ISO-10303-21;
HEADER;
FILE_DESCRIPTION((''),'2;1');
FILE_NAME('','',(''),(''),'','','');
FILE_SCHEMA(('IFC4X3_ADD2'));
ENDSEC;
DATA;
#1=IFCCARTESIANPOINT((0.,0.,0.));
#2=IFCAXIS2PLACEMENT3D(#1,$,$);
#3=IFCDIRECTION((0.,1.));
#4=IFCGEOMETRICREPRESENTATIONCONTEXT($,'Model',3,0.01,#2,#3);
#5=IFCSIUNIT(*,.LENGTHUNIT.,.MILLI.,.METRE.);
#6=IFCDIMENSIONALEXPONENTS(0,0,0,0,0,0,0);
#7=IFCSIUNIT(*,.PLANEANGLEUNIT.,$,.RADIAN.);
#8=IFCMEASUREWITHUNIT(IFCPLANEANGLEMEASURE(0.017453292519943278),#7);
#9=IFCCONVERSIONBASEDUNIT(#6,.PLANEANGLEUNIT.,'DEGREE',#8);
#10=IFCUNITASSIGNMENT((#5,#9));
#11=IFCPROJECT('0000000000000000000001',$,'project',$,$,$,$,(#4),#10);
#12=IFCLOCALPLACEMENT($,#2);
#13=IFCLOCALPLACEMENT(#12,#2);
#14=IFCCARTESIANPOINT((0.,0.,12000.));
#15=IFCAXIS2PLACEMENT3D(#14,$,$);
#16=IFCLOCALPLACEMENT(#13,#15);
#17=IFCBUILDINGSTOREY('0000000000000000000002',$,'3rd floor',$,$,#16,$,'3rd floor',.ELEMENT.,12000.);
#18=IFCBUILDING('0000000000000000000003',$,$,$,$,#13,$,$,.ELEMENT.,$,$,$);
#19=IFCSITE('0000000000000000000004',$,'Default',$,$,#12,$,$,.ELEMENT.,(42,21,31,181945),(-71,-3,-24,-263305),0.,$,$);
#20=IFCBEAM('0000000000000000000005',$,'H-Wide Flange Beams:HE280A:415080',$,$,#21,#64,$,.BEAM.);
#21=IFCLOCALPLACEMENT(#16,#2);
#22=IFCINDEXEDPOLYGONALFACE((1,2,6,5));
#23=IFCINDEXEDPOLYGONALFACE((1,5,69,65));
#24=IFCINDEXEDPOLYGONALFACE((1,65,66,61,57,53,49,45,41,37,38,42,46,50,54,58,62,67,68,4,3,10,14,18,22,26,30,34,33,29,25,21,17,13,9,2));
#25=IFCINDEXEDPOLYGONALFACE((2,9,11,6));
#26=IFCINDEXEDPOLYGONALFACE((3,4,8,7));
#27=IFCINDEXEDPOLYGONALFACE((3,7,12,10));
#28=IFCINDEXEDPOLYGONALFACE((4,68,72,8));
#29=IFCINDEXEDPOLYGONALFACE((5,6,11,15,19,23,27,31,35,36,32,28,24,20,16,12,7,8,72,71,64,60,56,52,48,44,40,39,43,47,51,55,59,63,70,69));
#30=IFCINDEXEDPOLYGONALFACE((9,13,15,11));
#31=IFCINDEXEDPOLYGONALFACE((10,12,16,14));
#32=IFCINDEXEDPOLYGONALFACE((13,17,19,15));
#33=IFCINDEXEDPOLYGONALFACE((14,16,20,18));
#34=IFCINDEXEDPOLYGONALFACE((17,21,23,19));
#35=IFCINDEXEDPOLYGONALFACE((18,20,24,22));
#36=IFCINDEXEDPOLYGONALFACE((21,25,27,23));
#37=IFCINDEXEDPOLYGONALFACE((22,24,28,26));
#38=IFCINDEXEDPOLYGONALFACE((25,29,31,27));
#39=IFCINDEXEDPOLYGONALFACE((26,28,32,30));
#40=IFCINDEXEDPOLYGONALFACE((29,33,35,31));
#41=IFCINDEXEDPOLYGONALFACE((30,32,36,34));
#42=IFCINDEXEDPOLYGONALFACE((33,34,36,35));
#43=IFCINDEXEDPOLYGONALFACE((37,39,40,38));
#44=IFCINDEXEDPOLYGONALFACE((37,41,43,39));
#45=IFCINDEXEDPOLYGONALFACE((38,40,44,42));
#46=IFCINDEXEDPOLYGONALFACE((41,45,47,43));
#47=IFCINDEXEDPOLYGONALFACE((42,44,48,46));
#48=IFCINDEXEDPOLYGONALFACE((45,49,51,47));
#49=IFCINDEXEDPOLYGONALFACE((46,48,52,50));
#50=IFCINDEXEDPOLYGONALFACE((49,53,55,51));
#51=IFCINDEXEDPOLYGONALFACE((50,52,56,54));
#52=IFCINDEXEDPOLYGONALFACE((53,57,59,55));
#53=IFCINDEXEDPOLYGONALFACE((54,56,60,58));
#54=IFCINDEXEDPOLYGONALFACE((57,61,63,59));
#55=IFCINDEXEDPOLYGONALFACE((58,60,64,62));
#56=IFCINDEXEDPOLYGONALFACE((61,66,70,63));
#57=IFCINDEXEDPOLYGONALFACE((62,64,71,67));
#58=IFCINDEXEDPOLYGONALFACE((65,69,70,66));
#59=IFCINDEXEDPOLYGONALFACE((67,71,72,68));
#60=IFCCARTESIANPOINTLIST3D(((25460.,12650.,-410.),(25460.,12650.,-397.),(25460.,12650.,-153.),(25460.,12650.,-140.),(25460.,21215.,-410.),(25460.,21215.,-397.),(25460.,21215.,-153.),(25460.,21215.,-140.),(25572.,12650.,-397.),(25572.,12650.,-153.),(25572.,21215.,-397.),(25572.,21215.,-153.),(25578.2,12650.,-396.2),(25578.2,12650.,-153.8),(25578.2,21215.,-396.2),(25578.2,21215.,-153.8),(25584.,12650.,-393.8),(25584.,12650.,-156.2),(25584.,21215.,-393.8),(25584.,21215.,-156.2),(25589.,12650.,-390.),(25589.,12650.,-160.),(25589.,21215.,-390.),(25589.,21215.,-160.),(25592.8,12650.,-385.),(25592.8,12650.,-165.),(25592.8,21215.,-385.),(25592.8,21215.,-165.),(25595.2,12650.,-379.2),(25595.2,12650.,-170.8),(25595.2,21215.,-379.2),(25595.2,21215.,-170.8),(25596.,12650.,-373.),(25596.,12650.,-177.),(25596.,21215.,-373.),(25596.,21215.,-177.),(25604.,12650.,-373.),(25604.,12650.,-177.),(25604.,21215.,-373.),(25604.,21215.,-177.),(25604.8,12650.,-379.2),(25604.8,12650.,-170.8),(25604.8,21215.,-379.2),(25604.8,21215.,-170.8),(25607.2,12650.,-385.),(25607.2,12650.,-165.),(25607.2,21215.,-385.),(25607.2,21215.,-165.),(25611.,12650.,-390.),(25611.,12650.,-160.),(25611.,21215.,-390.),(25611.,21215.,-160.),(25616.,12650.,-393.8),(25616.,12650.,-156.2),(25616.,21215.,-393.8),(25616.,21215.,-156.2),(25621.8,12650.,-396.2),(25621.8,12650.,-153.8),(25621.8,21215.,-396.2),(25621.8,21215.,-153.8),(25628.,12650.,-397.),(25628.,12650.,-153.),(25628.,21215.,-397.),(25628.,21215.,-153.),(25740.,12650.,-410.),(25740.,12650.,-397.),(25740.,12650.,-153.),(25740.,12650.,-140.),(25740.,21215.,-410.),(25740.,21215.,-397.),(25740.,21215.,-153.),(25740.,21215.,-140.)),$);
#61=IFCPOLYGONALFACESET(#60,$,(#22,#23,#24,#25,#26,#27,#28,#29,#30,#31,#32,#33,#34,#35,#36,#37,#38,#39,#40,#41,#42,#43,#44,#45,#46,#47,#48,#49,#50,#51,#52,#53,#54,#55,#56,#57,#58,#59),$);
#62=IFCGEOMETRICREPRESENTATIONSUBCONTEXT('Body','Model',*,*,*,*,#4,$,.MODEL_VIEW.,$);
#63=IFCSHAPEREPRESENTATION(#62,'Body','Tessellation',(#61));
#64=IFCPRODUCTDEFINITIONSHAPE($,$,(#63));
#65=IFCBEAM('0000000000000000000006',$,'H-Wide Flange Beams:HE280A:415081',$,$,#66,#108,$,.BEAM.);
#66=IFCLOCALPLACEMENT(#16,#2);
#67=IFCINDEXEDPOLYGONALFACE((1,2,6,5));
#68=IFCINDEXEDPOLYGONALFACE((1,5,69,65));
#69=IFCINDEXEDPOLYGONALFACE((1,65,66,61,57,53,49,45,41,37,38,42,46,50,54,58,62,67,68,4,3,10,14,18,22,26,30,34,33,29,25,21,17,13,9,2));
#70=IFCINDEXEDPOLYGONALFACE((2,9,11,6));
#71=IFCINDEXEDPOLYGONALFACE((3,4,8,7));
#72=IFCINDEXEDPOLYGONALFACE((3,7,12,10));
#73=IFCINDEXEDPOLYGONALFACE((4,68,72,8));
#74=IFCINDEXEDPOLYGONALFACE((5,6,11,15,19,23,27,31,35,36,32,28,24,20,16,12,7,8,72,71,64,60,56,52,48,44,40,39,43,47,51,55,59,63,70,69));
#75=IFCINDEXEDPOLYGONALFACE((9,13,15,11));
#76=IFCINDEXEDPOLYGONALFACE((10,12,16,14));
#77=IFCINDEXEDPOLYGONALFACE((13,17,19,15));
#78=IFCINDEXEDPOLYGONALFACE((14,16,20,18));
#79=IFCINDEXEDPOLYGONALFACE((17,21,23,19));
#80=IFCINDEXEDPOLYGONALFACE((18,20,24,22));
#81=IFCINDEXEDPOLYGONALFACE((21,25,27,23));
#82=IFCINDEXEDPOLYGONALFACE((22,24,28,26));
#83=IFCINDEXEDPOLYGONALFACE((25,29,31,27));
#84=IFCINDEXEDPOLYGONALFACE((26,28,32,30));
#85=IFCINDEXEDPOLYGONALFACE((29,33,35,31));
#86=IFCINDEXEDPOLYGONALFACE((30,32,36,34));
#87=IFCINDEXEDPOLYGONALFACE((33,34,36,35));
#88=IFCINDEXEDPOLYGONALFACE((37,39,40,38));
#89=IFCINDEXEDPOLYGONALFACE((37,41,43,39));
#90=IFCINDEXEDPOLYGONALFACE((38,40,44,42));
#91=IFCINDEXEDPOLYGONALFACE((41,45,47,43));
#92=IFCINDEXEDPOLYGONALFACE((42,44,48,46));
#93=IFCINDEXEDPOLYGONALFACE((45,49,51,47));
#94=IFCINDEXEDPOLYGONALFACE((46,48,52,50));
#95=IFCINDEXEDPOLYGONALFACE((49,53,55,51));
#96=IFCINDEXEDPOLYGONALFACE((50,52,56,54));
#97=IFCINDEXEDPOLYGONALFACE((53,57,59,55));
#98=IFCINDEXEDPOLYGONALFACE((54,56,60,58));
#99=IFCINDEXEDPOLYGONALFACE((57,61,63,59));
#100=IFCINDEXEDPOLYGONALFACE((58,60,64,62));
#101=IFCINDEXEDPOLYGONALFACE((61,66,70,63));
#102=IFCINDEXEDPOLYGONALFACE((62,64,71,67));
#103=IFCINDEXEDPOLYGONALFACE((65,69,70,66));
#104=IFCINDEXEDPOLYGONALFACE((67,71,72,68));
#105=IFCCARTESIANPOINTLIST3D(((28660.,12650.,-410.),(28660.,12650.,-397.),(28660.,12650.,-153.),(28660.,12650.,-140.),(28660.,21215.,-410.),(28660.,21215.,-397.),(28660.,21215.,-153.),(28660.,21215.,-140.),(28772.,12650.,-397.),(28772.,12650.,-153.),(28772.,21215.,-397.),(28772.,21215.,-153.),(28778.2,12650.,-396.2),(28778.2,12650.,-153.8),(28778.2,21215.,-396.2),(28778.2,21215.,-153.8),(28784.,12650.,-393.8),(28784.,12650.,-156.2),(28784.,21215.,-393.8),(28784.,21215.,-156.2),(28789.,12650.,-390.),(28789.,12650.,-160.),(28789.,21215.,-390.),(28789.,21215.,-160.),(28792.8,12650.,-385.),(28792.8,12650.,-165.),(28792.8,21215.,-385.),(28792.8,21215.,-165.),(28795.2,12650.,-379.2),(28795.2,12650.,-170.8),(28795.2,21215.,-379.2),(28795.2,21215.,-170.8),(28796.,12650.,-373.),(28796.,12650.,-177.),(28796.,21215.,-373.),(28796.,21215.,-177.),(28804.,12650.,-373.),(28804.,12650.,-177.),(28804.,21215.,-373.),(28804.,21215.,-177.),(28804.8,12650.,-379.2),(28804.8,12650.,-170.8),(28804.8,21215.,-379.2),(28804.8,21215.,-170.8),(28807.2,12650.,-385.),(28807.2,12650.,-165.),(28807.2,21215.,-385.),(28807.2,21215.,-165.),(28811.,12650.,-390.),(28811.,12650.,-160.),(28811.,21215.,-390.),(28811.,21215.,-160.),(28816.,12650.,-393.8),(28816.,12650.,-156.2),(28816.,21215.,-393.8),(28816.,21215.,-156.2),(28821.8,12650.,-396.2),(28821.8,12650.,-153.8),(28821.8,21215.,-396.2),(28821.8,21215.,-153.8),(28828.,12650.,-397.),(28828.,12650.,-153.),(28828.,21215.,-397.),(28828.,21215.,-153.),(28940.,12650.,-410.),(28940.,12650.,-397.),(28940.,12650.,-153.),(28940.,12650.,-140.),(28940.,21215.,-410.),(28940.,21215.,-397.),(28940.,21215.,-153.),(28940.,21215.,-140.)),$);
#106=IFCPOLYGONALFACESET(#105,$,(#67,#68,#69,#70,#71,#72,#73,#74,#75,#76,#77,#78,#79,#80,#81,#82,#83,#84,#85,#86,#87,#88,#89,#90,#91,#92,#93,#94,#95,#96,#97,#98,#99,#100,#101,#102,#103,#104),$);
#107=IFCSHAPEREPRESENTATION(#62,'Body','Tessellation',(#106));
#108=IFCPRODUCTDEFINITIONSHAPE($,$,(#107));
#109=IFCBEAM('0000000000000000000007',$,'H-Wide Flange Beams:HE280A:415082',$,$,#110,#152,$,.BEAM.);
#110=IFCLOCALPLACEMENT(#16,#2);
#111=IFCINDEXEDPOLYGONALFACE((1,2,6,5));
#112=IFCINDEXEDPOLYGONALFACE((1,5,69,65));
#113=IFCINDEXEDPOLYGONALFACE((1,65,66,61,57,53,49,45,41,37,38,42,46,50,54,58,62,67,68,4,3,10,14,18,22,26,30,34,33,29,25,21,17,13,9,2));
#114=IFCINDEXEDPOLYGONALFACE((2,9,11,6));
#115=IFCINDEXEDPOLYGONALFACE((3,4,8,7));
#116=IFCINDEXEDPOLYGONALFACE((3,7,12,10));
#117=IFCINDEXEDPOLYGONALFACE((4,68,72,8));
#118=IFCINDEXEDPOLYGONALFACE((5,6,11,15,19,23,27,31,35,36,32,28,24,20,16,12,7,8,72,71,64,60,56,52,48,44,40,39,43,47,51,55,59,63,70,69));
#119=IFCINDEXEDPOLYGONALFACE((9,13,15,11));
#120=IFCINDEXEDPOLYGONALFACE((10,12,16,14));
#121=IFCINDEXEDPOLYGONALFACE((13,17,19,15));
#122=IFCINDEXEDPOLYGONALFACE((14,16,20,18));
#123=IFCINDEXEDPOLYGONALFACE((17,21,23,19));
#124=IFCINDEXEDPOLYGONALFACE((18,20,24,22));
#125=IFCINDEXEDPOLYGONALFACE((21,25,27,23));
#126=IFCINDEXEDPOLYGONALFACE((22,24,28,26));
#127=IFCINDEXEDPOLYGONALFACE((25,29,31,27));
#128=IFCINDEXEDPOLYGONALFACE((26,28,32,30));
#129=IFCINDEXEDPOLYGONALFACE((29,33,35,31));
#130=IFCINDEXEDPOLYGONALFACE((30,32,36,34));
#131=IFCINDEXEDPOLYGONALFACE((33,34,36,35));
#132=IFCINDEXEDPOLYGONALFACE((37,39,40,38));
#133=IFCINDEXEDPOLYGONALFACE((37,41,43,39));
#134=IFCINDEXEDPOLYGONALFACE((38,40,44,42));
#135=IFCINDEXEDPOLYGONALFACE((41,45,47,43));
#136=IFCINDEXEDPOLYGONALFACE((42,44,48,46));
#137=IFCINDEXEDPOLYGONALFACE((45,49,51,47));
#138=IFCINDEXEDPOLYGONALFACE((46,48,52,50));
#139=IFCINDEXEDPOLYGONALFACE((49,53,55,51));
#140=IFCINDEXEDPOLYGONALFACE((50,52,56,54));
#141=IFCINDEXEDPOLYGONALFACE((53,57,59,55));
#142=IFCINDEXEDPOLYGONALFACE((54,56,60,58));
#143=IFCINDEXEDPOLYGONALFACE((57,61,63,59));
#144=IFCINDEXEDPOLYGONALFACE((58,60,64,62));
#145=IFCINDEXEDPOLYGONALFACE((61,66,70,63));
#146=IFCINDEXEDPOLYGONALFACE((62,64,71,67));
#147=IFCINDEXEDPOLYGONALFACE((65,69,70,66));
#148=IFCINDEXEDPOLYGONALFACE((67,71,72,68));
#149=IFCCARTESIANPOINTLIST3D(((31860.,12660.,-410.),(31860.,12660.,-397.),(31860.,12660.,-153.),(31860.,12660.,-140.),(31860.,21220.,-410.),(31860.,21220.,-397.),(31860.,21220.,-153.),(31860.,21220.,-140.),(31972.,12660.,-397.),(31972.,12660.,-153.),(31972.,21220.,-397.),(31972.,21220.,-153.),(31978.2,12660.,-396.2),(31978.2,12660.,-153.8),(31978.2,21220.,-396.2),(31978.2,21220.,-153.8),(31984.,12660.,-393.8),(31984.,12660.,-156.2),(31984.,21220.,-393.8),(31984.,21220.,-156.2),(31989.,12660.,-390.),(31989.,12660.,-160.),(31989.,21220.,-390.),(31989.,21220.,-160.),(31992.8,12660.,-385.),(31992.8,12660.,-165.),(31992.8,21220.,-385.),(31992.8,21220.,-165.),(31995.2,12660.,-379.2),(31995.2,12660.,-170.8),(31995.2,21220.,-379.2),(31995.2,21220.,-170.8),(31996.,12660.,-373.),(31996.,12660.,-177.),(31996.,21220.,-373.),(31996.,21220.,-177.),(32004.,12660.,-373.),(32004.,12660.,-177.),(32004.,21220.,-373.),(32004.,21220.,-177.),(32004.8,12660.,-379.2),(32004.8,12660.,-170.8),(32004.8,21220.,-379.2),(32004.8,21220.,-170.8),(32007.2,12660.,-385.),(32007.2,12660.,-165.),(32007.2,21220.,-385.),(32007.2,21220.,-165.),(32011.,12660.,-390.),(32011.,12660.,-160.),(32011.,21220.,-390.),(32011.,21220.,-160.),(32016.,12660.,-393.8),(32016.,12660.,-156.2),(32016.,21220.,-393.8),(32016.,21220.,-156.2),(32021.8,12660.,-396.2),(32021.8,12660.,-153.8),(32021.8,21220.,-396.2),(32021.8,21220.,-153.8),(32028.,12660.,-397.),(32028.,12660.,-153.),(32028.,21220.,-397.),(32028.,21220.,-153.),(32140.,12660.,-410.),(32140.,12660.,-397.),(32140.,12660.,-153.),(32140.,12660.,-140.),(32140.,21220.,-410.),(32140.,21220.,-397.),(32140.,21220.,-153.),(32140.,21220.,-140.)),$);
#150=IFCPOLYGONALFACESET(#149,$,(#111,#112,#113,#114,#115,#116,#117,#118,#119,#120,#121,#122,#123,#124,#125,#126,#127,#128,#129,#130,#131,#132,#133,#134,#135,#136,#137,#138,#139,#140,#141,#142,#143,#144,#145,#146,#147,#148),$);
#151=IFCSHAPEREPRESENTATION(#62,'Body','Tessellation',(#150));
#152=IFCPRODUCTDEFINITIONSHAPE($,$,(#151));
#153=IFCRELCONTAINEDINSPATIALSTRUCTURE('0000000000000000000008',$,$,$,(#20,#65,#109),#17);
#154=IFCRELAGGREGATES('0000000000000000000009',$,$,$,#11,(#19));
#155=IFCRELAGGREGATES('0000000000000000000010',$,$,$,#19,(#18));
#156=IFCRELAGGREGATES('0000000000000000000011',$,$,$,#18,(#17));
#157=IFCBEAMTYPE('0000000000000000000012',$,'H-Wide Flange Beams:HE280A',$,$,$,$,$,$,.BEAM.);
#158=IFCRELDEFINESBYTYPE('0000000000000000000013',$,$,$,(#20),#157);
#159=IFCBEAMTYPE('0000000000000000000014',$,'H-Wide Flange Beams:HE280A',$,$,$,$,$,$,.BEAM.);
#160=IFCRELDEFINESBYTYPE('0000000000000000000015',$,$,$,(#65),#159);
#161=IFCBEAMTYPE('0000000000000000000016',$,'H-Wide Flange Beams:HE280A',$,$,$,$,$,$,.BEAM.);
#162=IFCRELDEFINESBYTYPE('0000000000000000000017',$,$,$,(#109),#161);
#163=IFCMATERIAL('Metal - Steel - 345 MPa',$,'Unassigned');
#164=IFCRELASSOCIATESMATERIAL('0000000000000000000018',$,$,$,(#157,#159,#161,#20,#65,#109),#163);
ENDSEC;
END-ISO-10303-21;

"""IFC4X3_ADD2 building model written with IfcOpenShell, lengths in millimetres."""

from ifc_helpers import new_model, entity, si_unit, converted_unit, direction, frame, frame_2d, origin, place, context, subcontext, project, spatial, polyline, circle_curve, parameter, trimmed, segment, composite_curve, i_section, outline, extrude, source, transform, mapped, material, material_profile, profile_set, profile_usage, type_object, type_shapes, element, save


model = new_model("IFC4X3_ADD2")

# Units and contexts
model_context = context("Model", 3, precision=0.01, world=origin(), true_north=direction((0.0, 1.0)))
body_context = subcontext(model_context, "Body", "Model", "MODEL_VIEW")
ifc_project = project(units=[si_unit("LENGTHUNIT", "METRE", prefix="MILLI"), converted_unit("PLANEANGLEUNIT", "DEGREE", entity("IfcPlaneAngleMeasure", 0.017453292519943278), si_unit("PLANEANGLEUNIT", "RADIAN"), dimensions=[0, 0, 0, 0, 0, 0, 0])], contexts=[model_context])

# Site, building, storey
site_placement = place(None, origin())
site = spatial("IfcSite", under=ifc_project, at=site_placement, Name="Default", CompositionType="ELEMENT", RefLatitude=(42, 21, 31, 181945), RefLongitude=(-71, -3, -24, -263305), RefElevation=0.0)
building_placement = place(site_placement, origin())
building = spatial("IfcBuilding", under=site, at=building_placement, CompositionType="ELEMENT")
storey_placement = place(building_placement, frame((0.0, 0.0, 12000.0)))
storey = spatial("IfcBuildingStorey", under=building, at=storey_placement, Name="3rd floor", LongName="3rd floor", CompositionType="ELEMENT", Elevation=12000.0)

# Beams
ifc_material_1 = material(Name="Metal - Steel - 345 MPa", Category="Unassigned")
ifc_material_profile_1 = material_profile(ifc_material_1, outline(composite_curve([segment(polyline([(-140.0, -122.0), (-140.0, -135.0)]), True, "CONTINUOUS"), segment(polyline([(-140.0, -135.0), (140.0, -135.0)]), True, "CONTINUOUS"), segment(polyline([(140.0, -135.0), (140.0, -122.0)]), True, "CONTINUOUS"), segment(polyline([(140.0, -122.0), (28.0, -122.0)]), True, "CONTINUOUS"), segment(trimmed(circle_curve(frame_2d((28.0, -98.0), x_axis=(1.0, 0.0)), 24.0), [parameter(180.0)], [parameter(270.0)], True, "PARAMETER"), False, "CONTINUOUS"), segment(polyline([(4.0, -98.0), (4.0, 98.0)]), True, "CONTINUOUS"), segment(trimmed(circle_curve(frame_2d((28.0, 98.0), x_axis=(1.0, 0.0)), 24.0), [parameter(90.0)], [parameter(180.0)], True, "PARAMETER"), False, "CONTINUOUS"), segment(polyline([(28.0, 122.0), (140.0, 122.0)]), True, "CONTINUOUS"), segment(polyline([(140.0, 122.0), (140.0, 135.0)]), True, "CONTINUOUS"), segment(polyline([(140.0, 135.0), (-140.0, 135.0)]), True, "CONTINUOUS"), segment(polyline([(-140.0, 135.0), (-140.0, 122.0)]), True, "CONTINUOUS"), segment(polyline([(-140.0, 122.0), (-28.0, 122.0)]), True, "CONTINUOUS"), segment(trimmed(circle_curve(frame_2d((-28.0, 98.0), x_axis=(1.0, 0.0)), 24.0), [parameter(360.0)], [parameter(90.0)], True, "PARAMETER"), False, "CONTINUOUS"), segment(polyline([(-4.0, 98.0), (-4.0, -98.0)]), True, "CONTINUOUS"), segment(trimmed(circle_curve(frame_2d((-28.0, -98.0), x_axis=(1.0, 0.0)), 24.0), [parameter(270.0)], [parameter(360.0)], True, "PARAMETER"), False, "CONTINUOUS"), segment(polyline([(-28.0, -122.0), (-140.0, -122.0)]), True, "CONTINUOUS")], self_intersect=False)), Name="HE280A")
ifc_profile_set_1 = profile_set([ifc_material_profile_1], Name="HE280A")
ifc_profile_usage_1 = profile_usage(ifc_profile_set_1, cardinal=8)
beam_type_1 = type_object("IfcBeamType", Name="H-Wide Flange Beams:HE280A", PredefinedType="BEAM", material=ifc_profile_set_1)
shared_shape_1 = source(origin(), body_context, "Body", "SweptSolid", [
    extrude(i_section(OverallWidth=280.0, OverallDepth=270.0, WebThickness=8.0, FlangeThickness=13.0, FilletRadius=24.0, at=frame_2d((0.0, 0.0), x_axis=(1.0, 0.0))), frame((25600.0, 21215.0, 11725.0), z_axis=(0.0, -1.0, 0.0), x_axis=(-1.0, 0.0, 0.0)), (0.0, 0.0, 1.0), 8565.0),
])
type_shapes(beam_type_1, [shared_shape_1])
beam_1_placement = place(storey_placement, frame((0.0, 0.0, -12000.0)))
element("IfcBeam", 1, at=beam_1_placement, inside=storey, type_object=beam_type_1, material=ifc_profile_usage_1, Name="H-Wide Flange Beams:HE280A:415080", PredefinedType="BEAM", context=body_context, shape_type="MappedRepresentation", body=[
    mapped(shared_shape_1, transform((0.0, 0.0, 0.0), scale=1.0)),
])
beam_type_2 = type_object("IfcBeamType", Name="H-Wide Flange Beams:HE280A", PredefinedType="BEAM", material=ifc_profile_set_1)
shared_shape_2 = source(origin(), body_context, "Body", "SweptSolid", [
    extrude(i_section(OverallWidth=280.0, OverallDepth=270.0, WebThickness=8.0, FlangeThickness=13.0, FilletRadius=24.0, at=frame_2d((0.0, 0.0), x_axis=(1.0, 0.0))), frame((28800.0, 21215.0, 11725.0), z_axis=(0.0, -1.0, 0.0), x_axis=(-1.0, 0.0, 0.0)), (0.0, 0.0, 1.0), 8565.0),
])
type_shapes(beam_type_2, [shared_shape_2])
beam_2_placement = place(storey_placement, frame((0.0, 0.0, -12000.0)))
element("IfcBeam", 2, at=beam_2_placement, inside=storey, type_object=beam_type_2, material=ifc_profile_usage_1, Name="H-Wide Flange Beams:HE280A:415081", PredefinedType="BEAM", context=body_context, shape_type="MappedRepresentation", body=[
    mapped(shared_shape_2, transform((0.0, 0.0, 0.0), scale=1.0)),
])
beam_type_3 = type_object("IfcBeamType", Name="H-Wide Flange Beams:HE280A", PredefinedType="BEAM", material=ifc_profile_set_1)
shared_shape_3 = source(origin(), body_context, "Body", "SweptSolid", [
    extrude(i_section(OverallWidth=280.0, OverallDepth=270.0, WebThickness=8.0, FlangeThickness=13.0, FilletRadius=24.0, at=frame_2d((0.0, 0.0), x_axis=(1.0, 0.0))), frame((32000.0, 21220.0, 11725.0), z_axis=(0.0, -1.0, 0.0), x_axis=(-1.0, 0.0, 0.0)), (0.0, 0.0, 1.0), 8560.0),
])
type_shapes(beam_type_3, [shared_shape_3])
beam_3_placement = place(storey_placement, frame((0.0, 0.0, -12000.0)))
element("IfcBeam", 3, at=beam_3_placement, inside=storey, type_object=beam_type_3, material=ifc_profile_usage_1, Name="H-Wide Flange Beams:HE280A:415082", PredefinedType="BEAM", context=body_context, shape_type="MappedRepresentation", body=[
    mapped(shared_shape_3, transform((0.0, 0.0, 0.0), scale=1.0)),
])

save(model, "model.ifc")
